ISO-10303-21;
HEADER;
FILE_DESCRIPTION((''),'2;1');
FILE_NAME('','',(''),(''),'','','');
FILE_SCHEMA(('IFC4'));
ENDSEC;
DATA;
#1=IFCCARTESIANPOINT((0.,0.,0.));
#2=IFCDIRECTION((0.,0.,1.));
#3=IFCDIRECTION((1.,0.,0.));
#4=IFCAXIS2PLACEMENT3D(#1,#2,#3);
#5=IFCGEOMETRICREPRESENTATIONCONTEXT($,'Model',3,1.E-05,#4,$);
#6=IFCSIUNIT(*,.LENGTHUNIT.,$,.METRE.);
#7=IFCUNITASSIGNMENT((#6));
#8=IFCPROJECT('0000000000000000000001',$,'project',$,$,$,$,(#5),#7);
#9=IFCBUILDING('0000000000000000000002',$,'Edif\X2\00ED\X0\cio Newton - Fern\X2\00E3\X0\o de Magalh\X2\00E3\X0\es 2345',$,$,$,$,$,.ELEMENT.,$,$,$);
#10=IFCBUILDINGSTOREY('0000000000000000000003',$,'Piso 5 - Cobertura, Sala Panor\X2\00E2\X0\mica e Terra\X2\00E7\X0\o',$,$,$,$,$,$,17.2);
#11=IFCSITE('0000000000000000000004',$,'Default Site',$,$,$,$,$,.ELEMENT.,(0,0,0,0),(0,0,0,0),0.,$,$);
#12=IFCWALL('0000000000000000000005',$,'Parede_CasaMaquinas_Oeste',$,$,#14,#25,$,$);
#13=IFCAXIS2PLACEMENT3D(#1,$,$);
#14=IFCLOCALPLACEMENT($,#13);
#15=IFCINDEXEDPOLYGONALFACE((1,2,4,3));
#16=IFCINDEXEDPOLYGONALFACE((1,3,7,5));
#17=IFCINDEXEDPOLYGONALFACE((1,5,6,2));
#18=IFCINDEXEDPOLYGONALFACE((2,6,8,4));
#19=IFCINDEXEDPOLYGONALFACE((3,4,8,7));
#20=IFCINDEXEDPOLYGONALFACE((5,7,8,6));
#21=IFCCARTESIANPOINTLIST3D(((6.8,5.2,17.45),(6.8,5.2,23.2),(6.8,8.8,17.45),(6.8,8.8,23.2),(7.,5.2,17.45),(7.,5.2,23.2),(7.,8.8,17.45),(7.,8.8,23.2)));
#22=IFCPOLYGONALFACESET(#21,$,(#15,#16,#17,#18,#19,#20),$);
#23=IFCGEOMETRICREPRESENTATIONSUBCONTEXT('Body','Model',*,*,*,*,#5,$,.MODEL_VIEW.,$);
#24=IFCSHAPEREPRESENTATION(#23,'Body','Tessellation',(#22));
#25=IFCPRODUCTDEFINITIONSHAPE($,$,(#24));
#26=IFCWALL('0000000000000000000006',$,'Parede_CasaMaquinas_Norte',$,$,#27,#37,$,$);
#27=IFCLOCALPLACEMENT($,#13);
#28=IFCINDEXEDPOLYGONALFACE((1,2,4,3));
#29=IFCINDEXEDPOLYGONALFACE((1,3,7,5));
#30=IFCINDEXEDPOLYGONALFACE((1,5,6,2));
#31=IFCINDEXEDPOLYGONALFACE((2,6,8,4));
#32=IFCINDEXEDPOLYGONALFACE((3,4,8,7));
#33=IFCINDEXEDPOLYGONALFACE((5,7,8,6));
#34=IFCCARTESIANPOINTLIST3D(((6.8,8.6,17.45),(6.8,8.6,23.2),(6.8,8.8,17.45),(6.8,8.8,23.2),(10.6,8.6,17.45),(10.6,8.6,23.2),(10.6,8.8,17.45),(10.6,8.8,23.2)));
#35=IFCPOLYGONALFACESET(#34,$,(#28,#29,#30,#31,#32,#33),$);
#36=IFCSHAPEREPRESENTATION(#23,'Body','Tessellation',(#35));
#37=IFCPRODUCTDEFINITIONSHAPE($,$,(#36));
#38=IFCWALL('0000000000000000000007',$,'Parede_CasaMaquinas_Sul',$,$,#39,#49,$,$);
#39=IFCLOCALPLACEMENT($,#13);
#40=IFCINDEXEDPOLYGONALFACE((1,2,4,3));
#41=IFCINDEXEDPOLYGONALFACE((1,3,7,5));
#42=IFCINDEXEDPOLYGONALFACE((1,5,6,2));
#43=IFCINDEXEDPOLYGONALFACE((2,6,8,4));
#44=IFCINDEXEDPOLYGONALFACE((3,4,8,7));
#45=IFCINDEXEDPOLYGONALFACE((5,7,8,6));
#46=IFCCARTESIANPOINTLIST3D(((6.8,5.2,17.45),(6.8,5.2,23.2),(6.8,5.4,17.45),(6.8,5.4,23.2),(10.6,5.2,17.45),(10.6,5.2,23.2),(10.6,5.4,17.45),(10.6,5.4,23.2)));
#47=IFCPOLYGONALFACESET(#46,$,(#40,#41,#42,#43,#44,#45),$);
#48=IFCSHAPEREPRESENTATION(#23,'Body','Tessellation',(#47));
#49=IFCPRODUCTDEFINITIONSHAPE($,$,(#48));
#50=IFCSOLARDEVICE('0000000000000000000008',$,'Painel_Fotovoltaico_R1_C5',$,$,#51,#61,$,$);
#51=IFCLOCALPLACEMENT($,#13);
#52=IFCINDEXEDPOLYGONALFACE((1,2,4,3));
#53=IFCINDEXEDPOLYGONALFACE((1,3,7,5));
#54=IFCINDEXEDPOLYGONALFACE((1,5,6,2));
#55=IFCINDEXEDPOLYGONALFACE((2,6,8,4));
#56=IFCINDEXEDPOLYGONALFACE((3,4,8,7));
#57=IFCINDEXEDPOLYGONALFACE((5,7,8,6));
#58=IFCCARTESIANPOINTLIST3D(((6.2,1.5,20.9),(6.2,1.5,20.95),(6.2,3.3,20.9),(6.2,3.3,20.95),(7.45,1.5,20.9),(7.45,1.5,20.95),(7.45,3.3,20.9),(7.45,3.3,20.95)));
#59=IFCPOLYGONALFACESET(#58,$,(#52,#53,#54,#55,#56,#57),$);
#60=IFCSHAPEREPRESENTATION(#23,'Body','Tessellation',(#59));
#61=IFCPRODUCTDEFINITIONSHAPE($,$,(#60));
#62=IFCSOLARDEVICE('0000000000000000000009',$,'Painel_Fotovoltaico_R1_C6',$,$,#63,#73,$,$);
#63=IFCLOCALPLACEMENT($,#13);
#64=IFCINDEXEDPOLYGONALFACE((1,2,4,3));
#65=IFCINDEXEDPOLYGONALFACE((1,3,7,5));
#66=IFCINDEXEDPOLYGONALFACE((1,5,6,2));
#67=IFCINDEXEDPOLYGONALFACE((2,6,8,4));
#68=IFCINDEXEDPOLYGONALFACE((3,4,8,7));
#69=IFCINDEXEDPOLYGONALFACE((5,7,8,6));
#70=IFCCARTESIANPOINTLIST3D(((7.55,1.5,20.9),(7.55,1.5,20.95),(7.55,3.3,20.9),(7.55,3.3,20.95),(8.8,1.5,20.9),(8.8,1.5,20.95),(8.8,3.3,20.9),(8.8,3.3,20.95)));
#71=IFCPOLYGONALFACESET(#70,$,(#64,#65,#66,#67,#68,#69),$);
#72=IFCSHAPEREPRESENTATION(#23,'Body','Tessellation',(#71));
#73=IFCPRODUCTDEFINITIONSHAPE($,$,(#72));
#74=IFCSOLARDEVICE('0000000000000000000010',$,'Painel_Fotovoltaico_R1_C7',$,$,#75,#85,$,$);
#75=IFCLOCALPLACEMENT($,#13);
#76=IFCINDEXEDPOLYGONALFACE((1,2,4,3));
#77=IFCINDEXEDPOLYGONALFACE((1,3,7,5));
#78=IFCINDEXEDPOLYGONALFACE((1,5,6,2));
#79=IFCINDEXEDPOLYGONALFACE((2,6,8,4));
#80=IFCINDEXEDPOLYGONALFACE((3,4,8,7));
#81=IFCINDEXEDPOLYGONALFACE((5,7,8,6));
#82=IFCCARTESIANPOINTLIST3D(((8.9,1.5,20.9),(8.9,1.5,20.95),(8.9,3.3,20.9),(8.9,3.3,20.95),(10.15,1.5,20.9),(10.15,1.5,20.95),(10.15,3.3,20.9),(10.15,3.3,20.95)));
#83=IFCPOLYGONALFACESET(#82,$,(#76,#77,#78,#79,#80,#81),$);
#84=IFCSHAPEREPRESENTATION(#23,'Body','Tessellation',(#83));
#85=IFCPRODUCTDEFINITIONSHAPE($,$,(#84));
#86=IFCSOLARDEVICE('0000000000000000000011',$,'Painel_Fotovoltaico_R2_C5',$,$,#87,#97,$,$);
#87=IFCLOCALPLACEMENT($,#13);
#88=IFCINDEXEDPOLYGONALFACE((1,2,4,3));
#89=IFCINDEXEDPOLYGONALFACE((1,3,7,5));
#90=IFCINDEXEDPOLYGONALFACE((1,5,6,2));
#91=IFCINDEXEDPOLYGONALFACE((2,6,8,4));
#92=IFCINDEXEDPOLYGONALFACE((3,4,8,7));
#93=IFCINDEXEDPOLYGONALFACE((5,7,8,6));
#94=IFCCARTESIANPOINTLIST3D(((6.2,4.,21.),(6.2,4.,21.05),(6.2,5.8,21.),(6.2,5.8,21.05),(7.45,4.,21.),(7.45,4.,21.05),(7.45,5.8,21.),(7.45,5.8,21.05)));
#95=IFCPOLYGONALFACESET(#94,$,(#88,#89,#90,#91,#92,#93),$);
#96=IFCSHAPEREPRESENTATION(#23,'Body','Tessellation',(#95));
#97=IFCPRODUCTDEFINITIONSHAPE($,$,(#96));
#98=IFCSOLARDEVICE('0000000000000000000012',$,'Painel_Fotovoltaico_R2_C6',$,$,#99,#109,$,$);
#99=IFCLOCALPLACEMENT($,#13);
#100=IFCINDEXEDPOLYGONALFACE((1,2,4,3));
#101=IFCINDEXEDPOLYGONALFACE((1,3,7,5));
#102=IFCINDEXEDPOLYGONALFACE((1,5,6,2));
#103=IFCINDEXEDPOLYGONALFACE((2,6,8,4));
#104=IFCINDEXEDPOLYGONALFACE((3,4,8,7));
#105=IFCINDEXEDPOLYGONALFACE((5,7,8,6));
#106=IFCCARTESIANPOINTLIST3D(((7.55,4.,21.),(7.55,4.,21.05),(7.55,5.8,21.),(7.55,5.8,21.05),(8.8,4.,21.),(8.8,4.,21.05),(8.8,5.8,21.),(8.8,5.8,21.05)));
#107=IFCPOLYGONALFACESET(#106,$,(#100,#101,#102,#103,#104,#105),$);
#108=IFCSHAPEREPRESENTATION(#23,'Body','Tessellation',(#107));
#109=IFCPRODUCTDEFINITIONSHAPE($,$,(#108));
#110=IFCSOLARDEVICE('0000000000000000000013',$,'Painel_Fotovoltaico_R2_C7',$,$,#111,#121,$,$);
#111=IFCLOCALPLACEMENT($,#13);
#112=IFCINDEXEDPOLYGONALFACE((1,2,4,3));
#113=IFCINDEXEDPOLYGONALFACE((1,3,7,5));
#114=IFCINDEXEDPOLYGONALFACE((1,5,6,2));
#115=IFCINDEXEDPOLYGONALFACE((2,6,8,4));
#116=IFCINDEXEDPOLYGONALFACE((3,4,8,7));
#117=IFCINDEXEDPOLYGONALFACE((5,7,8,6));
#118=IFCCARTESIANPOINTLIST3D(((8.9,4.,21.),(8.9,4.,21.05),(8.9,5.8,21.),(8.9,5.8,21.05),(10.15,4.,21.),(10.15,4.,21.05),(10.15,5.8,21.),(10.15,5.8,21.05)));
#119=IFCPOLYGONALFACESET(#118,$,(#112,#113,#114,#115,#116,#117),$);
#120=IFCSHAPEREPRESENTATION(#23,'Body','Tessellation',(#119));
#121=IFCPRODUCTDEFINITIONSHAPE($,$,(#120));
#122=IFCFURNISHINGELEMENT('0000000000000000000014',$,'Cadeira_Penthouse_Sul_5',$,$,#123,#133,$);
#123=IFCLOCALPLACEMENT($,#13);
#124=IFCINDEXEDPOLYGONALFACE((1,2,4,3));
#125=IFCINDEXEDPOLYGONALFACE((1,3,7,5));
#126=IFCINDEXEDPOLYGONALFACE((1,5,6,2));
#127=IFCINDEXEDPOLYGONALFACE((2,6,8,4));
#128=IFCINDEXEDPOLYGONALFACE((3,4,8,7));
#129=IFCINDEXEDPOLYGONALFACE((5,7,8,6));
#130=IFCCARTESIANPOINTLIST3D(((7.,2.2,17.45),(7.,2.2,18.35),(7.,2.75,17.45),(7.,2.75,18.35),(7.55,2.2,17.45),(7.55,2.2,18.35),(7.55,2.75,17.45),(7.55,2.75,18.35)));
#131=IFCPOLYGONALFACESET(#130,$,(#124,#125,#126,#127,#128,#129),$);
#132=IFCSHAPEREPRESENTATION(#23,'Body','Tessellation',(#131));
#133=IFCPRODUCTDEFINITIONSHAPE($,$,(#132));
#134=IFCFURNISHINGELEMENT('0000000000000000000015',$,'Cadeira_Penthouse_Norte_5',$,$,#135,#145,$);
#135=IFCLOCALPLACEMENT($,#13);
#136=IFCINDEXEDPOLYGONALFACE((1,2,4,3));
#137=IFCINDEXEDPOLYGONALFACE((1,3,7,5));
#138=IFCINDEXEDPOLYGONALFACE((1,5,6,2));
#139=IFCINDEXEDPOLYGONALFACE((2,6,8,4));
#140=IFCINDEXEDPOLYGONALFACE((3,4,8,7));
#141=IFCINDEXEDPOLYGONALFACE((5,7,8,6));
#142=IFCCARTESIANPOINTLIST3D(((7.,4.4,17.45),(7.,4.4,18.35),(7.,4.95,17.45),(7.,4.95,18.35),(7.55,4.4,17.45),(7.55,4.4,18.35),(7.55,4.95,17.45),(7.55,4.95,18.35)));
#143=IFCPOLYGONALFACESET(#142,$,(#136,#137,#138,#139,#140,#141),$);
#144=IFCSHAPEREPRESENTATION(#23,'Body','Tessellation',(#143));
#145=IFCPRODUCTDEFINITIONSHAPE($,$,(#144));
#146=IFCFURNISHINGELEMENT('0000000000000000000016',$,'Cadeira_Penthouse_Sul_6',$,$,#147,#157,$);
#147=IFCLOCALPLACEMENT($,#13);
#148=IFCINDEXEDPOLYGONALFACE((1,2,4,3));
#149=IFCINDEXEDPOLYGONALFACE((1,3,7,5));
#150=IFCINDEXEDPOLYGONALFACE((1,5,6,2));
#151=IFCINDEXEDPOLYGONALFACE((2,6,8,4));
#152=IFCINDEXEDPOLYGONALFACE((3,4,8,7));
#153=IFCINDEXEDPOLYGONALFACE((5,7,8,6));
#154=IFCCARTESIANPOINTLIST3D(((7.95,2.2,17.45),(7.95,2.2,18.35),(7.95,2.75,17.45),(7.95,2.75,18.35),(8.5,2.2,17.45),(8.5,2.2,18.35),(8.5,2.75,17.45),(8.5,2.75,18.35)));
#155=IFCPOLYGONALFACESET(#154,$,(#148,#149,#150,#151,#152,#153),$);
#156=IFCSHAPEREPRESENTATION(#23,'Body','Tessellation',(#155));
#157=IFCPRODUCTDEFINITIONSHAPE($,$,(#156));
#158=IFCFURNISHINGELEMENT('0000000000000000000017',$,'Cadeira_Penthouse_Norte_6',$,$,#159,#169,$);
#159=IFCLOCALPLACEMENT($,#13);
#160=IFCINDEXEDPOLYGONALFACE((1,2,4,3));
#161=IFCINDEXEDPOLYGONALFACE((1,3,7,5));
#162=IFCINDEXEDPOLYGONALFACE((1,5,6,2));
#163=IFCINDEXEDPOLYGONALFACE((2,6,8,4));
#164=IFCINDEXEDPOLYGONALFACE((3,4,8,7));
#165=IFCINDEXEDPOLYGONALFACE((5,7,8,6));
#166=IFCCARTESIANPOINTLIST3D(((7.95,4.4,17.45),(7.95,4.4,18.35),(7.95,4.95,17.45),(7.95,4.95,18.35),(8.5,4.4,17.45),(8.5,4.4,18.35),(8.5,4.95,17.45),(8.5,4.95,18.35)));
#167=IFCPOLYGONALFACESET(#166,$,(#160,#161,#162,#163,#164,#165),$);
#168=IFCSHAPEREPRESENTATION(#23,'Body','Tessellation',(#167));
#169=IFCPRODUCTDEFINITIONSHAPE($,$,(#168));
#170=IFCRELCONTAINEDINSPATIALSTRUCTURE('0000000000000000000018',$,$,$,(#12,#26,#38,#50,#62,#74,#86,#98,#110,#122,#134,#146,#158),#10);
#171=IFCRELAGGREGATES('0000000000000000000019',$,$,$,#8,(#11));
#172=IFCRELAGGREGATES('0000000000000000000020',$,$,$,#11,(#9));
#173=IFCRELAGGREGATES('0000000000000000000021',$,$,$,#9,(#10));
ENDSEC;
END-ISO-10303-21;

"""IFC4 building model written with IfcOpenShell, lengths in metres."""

from ifc_helpers import new_model, si_unit, frame, frame_2d, origin_with_axes, place, context, subcontext, project, spatial, rectangle, extrude, element, save


model = new_model("IFC4")

# Units and contexts
model_context = context("Model", 3, precision=1e-05, world=origin_with_axes())
body_context = subcontext(model_context, "Body", "Model", "MODEL_VIEW")
ifc_project = project(units=[si_unit("LENGTHUNIT", "METRE")], contexts=[model_context])

# Site, building, storey
site = spatial("IfcSite", under=ifc_project, Name="Default Site", CompositionType="ELEMENT", RefLatitude=(0, 0, 0, 0), RefLongitude=(0, 0, 0, 0), RefElevation=0.0)
building = spatial("IfcBuilding", under=site, Name="Edifício Newton - Fernão de Magalhães 2345", CompositionType="ELEMENT")
storey = spatial("IfcBuildingStorey", under=building, Name="Piso 5 - Cobertura, Sala Panorâmica e Terraço", Elevation=17.2)

# Walls
wall_placement = place(None, frame((6.8, 5.2, 17.45), z_axis=(0.0, 0.0, 1.0), x_axis=(1.0, 0.0, 0.0)))
element("IfcWall", 1, at=wall_placement, inside=storey, Name="Parede_CasaMaquinas_Oeste", context=body_context, shape_type="SweptSolid", body=[
    extrude(rectangle(XDim=0.2, YDim=3.6, at=frame_2d((0.1, 1.8))), origin_with_axes(), (0.0, 0.0, 1.0), 5.75),
])
for number, where, z_axis, x_axis, name in (
    (2, (6.8, 8.6, 17.45), (0.0, 0.0, 1.0), (1.0, 0.0, 0.0), "Parede_CasaMaquinas_Norte"),
    (3, (6.8, 5.2, 17.45), (0.0, 0.0, 1.0), (1.0, 0.0, 0.0), "Parede_CasaMaquinas_Sul"),
):
    element("IfcWall", number, at=place(None, frame(where, z_axis=z_axis, x_axis=x_axis)), inside=storey, Name=name, context=body_context, shape_type="SweptSolid", body=[
        extrude(rectangle(XDim=3.8, YDim=0.2, at=frame_2d((1.9, 0.1))), origin_with_axes(), (0.0, 0.0, 1.0), 5.75),
    ])

# Solar devices
for number, where, z_axis, x_axis, name in (
    (4, (6.2, 1.5, 20.9), (0.0, 0.0, 1.0), (1.0, 0.0, 0.0), "Painel_Fotovoltaico_R1_C5"),
    (5, (7.55, 1.5, 20.9), (0.0, 0.0, 1.0), (1.0, 0.0, 0.0), "Painel_Fotovoltaico_R1_C6"),
    (6, (8.9, 1.5, 20.9), (0.0, 0.0, 1.0), (1.0, 0.0, 0.0), "Painel_Fotovoltaico_R1_C7"),
    (7, (6.2, 4.0, 21.0), (0.0, 0.0, 1.0), (1.0, 0.0, 0.0), "Painel_Fotovoltaico_R2_C5"),
    (8, (7.55, 4.0, 21.0), (0.0, 0.0, 1.0), (1.0, 0.0, 0.0), "Painel_Fotovoltaico_R2_C6"),
    (9, (8.9, 4.0, 21.0), (0.0, 0.0, 1.0), (1.0, 0.0, 0.0), "Painel_Fotovoltaico_R2_C7"),
):
    element("IfcSolarDevice", number, at=place(None, frame(where, z_axis=z_axis, x_axis=x_axis)), inside=storey, Name=name, context=body_context, shape_type="SweptSolid", body=[
        extrude(rectangle(XDim=1.25, YDim=1.8, at=frame_2d((0.625, 0.9))), origin_with_axes(), (0.0, 0.0, 1.0), 0.05),
    ])

# Furnishing elements
for number, where, z_axis, x_axis, name in (
    (10, (7.0, 2.2, 17.45), (0.0, 0.0, 1.0), (1.0, 0.0, 0.0), "Cadeira_Penthouse_Sul_5"),
    (11, (7.0, 4.4, 17.45), (0.0, 0.0, 1.0), (1.0, 0.0, 0.0), "Cadeira_Penthouse_Norte_5"),
    (12, (7.95, 2.2, 17.45), (0.0, 0.0, 1.0), (1.0, 0.0, 0.0), "Cadeira_Penthouse_Sul_6"),
    (13, (7.95, 4.4, 17.45), (0.0, 0.0, 1.0), (1.0, 0.0, 0.0), "Cadeira_Penthouse_Norte_6"),
):
    element("IfcFurnishingElement", number, at=place(None, frame(where, z_axis=z_axis, x_axis=x_axis)), inside=storey, Name=name, context=body_context, shape_type="SweptSolid", body=[
        extrude(rectangle(XDim=0.55, YDim=0.55, at=frame_2d((0.275, 0.275))), origin_with_axes(), (0.0, 0.0, 1.0), 0.9),
    ])

save(model, "model.ifc")
